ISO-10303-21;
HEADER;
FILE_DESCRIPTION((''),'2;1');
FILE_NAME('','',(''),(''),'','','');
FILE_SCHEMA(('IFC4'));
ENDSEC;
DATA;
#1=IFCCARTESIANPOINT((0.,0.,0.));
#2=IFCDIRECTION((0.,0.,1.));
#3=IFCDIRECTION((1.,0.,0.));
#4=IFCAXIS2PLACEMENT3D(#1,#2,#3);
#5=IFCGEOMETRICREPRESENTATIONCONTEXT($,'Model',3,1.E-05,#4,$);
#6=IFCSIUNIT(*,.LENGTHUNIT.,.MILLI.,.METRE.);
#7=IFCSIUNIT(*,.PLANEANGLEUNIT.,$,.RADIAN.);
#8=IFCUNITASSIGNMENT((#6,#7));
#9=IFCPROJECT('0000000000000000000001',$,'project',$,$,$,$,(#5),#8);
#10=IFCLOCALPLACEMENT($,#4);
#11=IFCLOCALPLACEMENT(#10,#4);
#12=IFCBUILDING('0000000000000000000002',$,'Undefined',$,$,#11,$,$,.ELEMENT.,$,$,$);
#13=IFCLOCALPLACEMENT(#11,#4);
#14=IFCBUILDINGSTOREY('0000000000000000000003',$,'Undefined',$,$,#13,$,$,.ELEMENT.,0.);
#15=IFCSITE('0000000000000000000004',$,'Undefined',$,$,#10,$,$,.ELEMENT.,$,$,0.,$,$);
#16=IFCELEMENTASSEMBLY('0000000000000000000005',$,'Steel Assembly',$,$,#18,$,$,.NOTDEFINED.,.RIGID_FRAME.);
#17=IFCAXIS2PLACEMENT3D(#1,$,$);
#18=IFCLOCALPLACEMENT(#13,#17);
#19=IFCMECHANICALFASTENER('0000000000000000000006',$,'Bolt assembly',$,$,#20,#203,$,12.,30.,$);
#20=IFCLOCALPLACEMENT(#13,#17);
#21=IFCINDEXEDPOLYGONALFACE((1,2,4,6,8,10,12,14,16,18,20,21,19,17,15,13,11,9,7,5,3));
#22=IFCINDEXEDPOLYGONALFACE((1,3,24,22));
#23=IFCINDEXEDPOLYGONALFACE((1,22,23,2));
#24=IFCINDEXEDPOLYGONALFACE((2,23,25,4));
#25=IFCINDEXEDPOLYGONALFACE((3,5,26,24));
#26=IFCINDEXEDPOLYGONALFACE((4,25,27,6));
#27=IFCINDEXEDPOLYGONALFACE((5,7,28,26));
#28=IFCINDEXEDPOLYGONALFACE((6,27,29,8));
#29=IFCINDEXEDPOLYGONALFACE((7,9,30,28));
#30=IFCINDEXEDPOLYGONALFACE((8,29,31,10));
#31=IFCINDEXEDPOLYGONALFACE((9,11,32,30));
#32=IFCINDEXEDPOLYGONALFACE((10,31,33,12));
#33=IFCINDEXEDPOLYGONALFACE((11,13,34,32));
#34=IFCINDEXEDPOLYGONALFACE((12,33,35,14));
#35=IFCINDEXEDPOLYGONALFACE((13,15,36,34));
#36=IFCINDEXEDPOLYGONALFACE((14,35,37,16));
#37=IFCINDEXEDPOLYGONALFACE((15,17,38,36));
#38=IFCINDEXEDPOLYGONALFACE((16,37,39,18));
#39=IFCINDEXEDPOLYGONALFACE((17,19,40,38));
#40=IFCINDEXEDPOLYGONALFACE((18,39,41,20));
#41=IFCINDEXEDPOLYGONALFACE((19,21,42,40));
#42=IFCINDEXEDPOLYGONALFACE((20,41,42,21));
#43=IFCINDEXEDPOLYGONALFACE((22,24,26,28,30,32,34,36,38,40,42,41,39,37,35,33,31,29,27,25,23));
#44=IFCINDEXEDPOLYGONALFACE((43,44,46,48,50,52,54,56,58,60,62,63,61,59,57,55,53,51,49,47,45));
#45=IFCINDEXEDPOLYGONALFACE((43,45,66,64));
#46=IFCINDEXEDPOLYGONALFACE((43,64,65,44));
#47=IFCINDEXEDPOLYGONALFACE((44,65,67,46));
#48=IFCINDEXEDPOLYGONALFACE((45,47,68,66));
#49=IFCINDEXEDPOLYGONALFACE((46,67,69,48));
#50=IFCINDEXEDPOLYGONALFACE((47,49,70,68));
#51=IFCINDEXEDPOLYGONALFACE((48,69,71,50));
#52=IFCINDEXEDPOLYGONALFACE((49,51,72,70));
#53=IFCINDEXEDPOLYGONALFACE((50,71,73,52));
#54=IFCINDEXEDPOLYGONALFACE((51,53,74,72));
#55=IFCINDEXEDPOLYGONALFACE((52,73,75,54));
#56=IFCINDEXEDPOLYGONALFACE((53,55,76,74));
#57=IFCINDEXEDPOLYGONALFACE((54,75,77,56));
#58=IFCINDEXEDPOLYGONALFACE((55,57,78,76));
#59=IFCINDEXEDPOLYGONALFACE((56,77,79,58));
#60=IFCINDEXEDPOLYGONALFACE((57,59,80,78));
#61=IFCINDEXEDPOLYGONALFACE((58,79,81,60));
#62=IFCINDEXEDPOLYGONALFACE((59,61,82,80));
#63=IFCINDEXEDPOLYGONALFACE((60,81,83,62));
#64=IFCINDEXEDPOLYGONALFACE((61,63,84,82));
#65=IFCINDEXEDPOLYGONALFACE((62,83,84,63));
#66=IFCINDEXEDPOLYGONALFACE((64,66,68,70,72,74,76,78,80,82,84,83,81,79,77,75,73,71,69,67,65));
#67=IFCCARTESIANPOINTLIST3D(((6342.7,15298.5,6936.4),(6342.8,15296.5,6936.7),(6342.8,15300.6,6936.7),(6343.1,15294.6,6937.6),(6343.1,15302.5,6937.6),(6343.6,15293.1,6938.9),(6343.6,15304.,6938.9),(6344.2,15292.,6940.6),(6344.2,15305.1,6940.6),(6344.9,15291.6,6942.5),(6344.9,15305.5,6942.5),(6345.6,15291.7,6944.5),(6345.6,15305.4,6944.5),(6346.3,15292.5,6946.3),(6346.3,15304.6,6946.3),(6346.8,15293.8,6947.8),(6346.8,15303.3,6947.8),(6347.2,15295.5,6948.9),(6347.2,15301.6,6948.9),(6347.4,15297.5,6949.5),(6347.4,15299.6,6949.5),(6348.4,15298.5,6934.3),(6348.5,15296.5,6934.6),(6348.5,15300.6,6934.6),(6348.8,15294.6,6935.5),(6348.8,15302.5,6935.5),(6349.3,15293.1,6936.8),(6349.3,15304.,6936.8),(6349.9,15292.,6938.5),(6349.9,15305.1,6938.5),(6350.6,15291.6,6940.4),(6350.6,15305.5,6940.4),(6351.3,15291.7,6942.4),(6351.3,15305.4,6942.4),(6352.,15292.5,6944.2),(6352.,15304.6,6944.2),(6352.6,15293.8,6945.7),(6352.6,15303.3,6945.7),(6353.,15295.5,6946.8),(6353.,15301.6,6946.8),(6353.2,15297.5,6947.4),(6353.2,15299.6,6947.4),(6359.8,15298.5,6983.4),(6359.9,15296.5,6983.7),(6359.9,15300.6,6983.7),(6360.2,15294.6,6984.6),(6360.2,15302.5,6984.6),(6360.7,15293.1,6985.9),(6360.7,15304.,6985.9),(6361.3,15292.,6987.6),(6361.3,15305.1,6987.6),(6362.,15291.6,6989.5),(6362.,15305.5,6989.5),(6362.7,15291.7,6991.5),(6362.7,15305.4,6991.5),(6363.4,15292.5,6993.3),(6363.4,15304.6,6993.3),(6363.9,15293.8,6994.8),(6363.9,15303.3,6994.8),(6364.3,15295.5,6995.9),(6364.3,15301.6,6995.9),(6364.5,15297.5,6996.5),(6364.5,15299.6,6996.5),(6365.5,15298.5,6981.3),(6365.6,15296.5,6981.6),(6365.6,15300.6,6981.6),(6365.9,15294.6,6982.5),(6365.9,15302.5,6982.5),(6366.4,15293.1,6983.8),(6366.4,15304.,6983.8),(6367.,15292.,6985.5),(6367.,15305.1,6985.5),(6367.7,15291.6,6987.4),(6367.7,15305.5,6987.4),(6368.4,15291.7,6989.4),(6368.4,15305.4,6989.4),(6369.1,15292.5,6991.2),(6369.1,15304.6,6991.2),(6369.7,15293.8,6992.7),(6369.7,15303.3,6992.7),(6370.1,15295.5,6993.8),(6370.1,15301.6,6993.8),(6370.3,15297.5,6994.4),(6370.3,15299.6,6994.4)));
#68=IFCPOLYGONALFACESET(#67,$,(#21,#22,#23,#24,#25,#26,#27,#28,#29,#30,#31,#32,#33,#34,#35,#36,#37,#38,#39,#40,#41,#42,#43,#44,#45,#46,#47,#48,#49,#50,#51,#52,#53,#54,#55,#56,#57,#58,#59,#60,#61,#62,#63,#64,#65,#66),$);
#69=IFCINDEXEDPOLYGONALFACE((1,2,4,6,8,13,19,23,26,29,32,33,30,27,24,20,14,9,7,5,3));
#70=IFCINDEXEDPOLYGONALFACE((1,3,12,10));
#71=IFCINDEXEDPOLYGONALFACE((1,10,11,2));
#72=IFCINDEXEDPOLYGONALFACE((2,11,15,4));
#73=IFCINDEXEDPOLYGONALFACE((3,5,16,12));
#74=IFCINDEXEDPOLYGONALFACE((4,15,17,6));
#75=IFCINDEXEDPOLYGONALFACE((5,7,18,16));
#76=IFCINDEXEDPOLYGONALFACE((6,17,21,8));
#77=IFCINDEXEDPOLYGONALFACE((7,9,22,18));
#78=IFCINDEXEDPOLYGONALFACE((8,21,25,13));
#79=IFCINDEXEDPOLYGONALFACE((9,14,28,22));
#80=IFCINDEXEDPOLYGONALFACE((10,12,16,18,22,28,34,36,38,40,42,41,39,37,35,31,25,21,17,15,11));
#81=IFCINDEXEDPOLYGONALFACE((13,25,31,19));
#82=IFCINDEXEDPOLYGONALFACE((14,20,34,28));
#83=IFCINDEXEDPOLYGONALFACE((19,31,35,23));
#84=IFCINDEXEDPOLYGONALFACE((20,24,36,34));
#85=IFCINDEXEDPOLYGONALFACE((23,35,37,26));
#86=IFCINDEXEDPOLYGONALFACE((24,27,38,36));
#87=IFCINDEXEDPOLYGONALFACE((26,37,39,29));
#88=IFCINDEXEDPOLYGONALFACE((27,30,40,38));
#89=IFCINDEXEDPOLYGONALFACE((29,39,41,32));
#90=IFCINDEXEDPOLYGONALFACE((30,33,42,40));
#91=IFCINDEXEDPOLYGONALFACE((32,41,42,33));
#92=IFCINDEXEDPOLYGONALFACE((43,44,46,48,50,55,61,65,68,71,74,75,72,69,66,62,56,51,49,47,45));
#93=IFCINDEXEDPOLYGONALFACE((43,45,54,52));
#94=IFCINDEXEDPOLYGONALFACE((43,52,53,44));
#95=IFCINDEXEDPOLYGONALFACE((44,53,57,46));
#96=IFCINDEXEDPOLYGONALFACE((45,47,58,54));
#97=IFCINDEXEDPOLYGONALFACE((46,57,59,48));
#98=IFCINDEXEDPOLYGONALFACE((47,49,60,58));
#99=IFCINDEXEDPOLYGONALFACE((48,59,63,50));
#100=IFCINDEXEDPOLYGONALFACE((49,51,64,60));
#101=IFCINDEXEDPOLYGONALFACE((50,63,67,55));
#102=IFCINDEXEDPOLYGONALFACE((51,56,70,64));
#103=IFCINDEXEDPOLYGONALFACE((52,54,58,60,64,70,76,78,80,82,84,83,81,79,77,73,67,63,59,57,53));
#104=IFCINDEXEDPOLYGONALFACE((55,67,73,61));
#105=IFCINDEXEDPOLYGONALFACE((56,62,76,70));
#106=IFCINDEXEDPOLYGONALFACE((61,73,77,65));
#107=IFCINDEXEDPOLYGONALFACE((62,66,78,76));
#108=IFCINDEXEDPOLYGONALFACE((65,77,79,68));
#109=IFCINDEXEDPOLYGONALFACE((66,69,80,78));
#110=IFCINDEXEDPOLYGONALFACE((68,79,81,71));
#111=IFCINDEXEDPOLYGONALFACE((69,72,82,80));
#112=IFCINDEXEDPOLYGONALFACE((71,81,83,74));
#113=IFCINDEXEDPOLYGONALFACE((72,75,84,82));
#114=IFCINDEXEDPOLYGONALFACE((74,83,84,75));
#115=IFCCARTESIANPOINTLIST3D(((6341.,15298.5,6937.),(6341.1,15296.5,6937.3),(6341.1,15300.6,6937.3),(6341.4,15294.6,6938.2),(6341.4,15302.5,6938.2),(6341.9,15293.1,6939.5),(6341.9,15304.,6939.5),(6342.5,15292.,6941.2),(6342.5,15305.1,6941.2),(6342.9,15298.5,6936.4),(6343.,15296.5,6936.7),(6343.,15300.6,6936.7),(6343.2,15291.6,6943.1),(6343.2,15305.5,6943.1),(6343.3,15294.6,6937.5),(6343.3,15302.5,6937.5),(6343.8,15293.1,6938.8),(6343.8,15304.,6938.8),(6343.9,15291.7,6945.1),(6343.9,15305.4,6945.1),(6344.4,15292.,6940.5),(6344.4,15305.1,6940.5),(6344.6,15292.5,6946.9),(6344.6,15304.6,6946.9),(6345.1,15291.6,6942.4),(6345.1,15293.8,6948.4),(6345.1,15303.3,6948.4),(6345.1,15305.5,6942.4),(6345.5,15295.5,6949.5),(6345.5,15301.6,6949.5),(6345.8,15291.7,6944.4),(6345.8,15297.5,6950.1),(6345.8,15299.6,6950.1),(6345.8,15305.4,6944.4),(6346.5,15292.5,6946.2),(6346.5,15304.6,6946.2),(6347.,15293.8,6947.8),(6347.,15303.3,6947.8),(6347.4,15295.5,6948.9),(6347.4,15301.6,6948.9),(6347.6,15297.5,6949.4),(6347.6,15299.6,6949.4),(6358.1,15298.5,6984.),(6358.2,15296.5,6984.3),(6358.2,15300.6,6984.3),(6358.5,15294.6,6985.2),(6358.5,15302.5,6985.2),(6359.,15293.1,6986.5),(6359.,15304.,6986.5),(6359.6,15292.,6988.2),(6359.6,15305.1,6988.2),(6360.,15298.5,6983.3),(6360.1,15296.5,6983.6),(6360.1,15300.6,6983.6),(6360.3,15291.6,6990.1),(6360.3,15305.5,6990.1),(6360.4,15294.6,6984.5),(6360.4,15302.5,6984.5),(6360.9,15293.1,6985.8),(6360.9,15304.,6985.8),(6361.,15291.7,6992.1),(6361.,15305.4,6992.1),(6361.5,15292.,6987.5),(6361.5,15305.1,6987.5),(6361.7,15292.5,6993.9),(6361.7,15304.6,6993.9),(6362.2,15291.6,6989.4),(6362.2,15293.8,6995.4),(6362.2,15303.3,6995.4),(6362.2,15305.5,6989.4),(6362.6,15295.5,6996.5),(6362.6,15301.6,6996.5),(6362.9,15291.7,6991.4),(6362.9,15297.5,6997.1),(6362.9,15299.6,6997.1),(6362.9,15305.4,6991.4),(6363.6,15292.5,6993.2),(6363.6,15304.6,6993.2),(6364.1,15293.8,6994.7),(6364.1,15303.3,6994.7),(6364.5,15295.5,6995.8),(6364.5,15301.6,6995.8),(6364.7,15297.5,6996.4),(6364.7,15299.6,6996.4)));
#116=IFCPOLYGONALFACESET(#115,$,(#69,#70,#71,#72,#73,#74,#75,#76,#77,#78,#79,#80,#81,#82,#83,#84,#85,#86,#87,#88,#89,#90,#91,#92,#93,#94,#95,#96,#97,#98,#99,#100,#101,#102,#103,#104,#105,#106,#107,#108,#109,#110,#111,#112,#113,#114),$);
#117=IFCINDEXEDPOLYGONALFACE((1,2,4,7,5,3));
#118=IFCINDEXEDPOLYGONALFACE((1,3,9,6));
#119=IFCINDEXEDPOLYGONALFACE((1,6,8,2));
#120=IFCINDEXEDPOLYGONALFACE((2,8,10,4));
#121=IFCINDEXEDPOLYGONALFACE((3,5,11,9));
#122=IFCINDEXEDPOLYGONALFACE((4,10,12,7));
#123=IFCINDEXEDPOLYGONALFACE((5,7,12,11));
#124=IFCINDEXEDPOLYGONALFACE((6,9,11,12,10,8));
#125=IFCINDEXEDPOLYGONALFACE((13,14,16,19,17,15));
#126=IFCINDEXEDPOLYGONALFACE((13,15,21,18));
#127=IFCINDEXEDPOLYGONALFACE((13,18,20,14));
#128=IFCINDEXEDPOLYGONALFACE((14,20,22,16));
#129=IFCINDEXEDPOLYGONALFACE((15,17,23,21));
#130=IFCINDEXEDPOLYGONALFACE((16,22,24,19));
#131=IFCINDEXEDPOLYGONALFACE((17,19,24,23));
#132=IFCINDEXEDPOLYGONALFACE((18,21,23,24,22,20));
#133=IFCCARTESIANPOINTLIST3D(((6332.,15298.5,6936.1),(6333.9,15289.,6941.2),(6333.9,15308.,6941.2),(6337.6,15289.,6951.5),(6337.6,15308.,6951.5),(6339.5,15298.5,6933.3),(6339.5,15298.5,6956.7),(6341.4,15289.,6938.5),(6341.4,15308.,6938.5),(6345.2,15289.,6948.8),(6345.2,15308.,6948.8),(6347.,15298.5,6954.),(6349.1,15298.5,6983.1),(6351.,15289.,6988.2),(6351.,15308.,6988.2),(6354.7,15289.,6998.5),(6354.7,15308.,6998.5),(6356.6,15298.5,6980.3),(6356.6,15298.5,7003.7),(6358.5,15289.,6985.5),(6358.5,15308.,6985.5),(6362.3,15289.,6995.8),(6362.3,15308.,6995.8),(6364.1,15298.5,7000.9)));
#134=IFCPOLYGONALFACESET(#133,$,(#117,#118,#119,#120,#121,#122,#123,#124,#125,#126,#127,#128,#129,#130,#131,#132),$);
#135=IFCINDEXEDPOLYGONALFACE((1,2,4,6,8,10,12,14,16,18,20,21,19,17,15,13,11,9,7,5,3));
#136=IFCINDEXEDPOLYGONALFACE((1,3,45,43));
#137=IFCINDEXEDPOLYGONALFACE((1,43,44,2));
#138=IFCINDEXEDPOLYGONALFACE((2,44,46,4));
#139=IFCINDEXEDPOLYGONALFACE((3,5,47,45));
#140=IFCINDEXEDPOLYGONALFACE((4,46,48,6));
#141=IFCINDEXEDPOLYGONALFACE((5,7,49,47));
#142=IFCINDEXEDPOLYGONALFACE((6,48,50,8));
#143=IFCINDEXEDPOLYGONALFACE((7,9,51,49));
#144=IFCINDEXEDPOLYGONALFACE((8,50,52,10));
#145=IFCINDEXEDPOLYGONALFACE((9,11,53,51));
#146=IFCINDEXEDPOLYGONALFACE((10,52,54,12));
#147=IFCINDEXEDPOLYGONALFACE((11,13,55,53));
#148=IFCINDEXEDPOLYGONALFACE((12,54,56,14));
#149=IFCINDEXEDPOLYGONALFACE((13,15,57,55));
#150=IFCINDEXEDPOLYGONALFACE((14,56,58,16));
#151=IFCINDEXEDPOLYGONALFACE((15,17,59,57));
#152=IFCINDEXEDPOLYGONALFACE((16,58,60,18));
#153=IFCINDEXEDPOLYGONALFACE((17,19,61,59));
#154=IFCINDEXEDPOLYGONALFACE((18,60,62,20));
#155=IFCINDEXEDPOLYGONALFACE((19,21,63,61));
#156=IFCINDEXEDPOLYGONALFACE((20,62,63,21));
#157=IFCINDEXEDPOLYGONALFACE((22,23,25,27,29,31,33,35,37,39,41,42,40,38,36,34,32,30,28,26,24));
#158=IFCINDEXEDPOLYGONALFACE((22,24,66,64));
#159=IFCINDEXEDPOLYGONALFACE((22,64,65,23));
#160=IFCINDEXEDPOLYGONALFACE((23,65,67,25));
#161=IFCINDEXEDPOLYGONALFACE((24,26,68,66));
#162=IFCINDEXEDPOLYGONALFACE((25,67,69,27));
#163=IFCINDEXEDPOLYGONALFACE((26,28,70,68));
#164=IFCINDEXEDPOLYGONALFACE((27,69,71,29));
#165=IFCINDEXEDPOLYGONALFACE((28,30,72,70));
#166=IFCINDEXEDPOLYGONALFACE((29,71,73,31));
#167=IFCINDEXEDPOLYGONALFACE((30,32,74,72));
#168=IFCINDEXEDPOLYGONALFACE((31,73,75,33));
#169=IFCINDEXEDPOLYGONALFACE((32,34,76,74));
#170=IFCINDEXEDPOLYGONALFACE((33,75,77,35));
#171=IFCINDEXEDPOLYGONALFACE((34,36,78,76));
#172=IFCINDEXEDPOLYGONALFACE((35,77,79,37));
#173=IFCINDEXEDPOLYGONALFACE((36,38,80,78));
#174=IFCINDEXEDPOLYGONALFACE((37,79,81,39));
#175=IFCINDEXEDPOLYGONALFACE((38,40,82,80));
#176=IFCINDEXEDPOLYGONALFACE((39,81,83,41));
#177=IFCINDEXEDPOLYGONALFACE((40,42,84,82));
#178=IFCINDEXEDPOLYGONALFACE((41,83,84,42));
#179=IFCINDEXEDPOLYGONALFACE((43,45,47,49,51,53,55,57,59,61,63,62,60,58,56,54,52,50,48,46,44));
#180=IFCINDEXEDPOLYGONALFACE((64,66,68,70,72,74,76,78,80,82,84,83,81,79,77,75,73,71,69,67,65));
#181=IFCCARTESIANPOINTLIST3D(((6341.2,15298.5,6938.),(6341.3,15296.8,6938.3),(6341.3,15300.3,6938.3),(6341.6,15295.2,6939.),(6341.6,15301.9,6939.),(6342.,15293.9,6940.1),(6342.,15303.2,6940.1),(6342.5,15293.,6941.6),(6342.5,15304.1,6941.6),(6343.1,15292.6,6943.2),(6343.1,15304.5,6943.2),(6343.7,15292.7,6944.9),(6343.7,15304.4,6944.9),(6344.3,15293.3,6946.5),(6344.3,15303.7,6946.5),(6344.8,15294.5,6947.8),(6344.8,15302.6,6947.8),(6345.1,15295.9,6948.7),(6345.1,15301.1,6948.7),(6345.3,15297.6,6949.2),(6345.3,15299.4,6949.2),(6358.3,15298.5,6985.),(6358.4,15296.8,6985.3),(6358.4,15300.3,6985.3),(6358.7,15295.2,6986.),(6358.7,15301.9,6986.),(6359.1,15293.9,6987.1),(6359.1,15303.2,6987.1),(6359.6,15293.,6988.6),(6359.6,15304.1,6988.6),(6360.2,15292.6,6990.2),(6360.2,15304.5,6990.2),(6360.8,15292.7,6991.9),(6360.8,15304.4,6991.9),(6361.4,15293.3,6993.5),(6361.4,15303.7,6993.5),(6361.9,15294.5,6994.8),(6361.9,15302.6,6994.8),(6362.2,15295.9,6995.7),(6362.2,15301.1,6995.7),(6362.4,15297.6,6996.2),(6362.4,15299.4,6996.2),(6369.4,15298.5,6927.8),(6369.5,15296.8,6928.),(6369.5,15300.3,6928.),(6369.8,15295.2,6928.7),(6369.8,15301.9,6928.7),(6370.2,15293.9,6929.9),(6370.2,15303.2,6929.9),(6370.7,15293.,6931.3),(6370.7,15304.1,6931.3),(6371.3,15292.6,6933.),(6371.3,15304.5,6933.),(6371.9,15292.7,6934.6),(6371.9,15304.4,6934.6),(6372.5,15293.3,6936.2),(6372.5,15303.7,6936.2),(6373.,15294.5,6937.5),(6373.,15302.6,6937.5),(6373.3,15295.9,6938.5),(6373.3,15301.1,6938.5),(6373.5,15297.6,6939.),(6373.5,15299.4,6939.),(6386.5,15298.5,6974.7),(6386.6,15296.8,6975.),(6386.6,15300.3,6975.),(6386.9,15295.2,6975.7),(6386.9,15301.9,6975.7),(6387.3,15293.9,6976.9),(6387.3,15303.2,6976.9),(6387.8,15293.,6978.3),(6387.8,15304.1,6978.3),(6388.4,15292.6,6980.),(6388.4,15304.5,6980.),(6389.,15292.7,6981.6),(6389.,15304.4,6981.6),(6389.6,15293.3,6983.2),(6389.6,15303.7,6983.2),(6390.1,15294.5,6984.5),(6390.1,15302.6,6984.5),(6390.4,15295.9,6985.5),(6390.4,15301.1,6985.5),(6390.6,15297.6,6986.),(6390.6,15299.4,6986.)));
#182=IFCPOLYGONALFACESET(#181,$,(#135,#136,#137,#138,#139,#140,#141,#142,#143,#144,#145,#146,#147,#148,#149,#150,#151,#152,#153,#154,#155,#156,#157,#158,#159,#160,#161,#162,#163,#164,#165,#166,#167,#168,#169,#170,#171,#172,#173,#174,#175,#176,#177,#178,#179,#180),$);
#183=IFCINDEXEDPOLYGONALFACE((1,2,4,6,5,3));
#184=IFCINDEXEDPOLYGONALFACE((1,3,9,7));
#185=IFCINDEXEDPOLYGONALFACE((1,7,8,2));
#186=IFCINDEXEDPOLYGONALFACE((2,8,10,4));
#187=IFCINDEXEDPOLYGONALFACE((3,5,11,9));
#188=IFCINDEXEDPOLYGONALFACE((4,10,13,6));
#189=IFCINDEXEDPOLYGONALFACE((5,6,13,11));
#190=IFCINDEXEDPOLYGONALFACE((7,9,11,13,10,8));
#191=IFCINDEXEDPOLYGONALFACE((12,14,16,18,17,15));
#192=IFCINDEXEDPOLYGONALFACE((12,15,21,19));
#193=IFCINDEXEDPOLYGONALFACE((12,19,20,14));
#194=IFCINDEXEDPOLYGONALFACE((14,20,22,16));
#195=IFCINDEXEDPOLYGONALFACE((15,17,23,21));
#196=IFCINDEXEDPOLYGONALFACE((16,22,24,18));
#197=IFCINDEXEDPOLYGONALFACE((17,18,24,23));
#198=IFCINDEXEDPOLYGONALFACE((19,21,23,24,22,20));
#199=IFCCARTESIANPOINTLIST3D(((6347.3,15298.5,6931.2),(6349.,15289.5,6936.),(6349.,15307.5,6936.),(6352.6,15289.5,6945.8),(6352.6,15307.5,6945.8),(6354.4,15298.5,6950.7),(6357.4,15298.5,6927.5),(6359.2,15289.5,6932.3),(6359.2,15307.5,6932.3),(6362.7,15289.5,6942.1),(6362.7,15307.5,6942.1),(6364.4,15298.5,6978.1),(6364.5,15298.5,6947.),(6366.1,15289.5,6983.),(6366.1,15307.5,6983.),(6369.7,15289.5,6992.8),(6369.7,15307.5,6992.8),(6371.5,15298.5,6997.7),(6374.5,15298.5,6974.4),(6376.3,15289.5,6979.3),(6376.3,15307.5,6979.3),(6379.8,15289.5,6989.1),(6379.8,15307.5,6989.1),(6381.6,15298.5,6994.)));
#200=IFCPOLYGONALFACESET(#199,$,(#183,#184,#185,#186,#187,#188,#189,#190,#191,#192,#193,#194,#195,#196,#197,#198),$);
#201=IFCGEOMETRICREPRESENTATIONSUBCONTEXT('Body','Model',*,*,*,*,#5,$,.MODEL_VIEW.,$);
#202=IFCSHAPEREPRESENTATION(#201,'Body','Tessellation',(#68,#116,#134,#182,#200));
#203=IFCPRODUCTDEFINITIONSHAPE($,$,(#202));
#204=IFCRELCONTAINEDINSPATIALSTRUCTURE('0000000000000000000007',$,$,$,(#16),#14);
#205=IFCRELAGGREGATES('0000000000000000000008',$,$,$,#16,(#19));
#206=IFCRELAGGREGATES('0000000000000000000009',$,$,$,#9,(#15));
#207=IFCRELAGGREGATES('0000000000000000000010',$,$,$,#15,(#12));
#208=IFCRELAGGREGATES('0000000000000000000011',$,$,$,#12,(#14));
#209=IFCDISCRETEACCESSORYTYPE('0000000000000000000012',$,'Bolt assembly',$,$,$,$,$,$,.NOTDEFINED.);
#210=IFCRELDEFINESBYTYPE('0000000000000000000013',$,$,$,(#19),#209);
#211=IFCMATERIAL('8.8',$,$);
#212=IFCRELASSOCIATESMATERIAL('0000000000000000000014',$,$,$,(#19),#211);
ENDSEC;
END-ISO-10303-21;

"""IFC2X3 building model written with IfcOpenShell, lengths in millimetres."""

from ifc_helpers import new_model, si_unit, frame, origin_with_axes, origin_2d_with_axis, place, context, subcontext, project, spatial, polyline, circle, outline, extrude, source, transform, mapped, material, type_object, element, aggregate, save


model = new_model("IFC2X3")

# Units and contexts
model_context = context("Model", 3, precision=1e-05, world=origin_with_axes())
body_context = subcontext(model_context, "Body", "Model", "MODEL_VIEW")
ifc_project = project(units=[si_unit("LENGTHUNIT", "METRE", prefix="MILLI"), si_unit("PLANEANGLEUNIT", "RADIAN")], contexts=[model_context])

# Site, building, storey
site_placement = place(None, origin_with_axes())
site = spatial("IfcSite", under=ifc_project, at=site_placement, Name="Undefined", CompositionType="ELEMENT", RefElevation=0.0)
building_placement = place(site_placement, origin_with_axes())
building = spatial("IfcBuilding", under=site, at=building_placement, Name="Undefined", CompositionType="ELEMENT")
storey_placement = place(building_placement, origin_with_axes())
storey = spatial("IfcBuildingStorey", under=building, at=storey_placement, Name="Undefined", CompositionType="ELEMENT", Elevation=0.0)

# Shared definitions
ifc_material_1 = material(Name="8.8")
discrete_accessory_type_1 = type_object("IfcDiscreteAccessoryType", Name="Bolt assembly")

# Element assembly, mechanical fastener
shared_shape_1 = source(origin_with_axes(), body_context, "Body", "SweptSolid", [
    extrude(circle(Radius=7.0, at=origin_2d_with_axis()), frame((0.0, -6.1, 0.0), z_axis=(0.0, 1.0, 0.0), x_axis=(1.0, 0.0, 0.0)), (0.0, 0.0, 1.0), 6.1),
    extrude(circle(Radius=7.0, at=origin_2d_with_axis()), frame((0.0, -7.9, 0.0), z_axis=(0.0, 1.0, 0.0), x_axis=(1.0, 0.0, 0.0)), (0.0, 0.0, 1.0), 2.0),
    extrude(outline(polyline([(11.0, 0.0), (5.5, 9.5), (-5.5, 9.5), (-11.0, 0.0), (-5.5, -9.5), (5.5, -9.5), (11.0, 0.0)])), frame((0.0, -16.0, 0.0), z_axis=(0.0, 1.0, 0.0), x_axis=(1.0, 0.0, 0.0)), (0.0, 0.0, 1.0), 8.0),
    extrude(circle(Radius=6.0, at=origin_2d_with_axis()), frame((0.0, -8.0, 0.0), z_axis=(0.0, 1.0, 0.0), x_axis=(1.0, 0.0, 0.0)), (0.0, 0.0, 1.0), 30.0),
    extrude(outline(polyline([(10.4, 0.0), (5.2, 9.0), (-5.2, 9.0), (-10.4, 0.0), (-5.2, -9.0), (5.2, -9.0), (10.4, 0.0)])), frame((0.0, 0.0, 0.0), z_axis=(0.0, 1.0, 0.0), x_axis=(1.0, 0.0, 0.0)), (0.0, 0.0, 1.0), 10.8),
])
assembly_1_placement = place(storey_placement, origin_with_axes())
assembly_1 = element("IfcElementAssembly", 1, at=assembly_1_placement, inside=storey, Name="Steel Assembly", AssemblyPlace="NOTDEFINED", PredefinedType="RIGID_FRAME")
mechanical_fastener_1_placement = place(assembly_1_placement, frame((6367.9, 15298.5, 6987.9), z_axis=(0.0, -1.0, 0.0), x_axis=(-0.34202, 0.0, -0.939693)))
mechanical_fastener_1 = element("IfcMechanicalFastener", 2, at=mechanical_fastener_1_placement, type_object=discrete_accessory_type_1, material=ifc_material_1, Name="Bolt assembly", NominalDiameter=12.0, NominalLength=30.0, context=body_context, shape_type="MappedRepresentation", body=[
    mapped(shared_shape_1, transform((0.0, 0.0, 0.0))),
    mapped(shared_shape_1, transform((50.0, 0.0, 0.0))),
])
aggregate(assembly_1, [mechanical_fastener_1])

save(model, "model.ifc")
